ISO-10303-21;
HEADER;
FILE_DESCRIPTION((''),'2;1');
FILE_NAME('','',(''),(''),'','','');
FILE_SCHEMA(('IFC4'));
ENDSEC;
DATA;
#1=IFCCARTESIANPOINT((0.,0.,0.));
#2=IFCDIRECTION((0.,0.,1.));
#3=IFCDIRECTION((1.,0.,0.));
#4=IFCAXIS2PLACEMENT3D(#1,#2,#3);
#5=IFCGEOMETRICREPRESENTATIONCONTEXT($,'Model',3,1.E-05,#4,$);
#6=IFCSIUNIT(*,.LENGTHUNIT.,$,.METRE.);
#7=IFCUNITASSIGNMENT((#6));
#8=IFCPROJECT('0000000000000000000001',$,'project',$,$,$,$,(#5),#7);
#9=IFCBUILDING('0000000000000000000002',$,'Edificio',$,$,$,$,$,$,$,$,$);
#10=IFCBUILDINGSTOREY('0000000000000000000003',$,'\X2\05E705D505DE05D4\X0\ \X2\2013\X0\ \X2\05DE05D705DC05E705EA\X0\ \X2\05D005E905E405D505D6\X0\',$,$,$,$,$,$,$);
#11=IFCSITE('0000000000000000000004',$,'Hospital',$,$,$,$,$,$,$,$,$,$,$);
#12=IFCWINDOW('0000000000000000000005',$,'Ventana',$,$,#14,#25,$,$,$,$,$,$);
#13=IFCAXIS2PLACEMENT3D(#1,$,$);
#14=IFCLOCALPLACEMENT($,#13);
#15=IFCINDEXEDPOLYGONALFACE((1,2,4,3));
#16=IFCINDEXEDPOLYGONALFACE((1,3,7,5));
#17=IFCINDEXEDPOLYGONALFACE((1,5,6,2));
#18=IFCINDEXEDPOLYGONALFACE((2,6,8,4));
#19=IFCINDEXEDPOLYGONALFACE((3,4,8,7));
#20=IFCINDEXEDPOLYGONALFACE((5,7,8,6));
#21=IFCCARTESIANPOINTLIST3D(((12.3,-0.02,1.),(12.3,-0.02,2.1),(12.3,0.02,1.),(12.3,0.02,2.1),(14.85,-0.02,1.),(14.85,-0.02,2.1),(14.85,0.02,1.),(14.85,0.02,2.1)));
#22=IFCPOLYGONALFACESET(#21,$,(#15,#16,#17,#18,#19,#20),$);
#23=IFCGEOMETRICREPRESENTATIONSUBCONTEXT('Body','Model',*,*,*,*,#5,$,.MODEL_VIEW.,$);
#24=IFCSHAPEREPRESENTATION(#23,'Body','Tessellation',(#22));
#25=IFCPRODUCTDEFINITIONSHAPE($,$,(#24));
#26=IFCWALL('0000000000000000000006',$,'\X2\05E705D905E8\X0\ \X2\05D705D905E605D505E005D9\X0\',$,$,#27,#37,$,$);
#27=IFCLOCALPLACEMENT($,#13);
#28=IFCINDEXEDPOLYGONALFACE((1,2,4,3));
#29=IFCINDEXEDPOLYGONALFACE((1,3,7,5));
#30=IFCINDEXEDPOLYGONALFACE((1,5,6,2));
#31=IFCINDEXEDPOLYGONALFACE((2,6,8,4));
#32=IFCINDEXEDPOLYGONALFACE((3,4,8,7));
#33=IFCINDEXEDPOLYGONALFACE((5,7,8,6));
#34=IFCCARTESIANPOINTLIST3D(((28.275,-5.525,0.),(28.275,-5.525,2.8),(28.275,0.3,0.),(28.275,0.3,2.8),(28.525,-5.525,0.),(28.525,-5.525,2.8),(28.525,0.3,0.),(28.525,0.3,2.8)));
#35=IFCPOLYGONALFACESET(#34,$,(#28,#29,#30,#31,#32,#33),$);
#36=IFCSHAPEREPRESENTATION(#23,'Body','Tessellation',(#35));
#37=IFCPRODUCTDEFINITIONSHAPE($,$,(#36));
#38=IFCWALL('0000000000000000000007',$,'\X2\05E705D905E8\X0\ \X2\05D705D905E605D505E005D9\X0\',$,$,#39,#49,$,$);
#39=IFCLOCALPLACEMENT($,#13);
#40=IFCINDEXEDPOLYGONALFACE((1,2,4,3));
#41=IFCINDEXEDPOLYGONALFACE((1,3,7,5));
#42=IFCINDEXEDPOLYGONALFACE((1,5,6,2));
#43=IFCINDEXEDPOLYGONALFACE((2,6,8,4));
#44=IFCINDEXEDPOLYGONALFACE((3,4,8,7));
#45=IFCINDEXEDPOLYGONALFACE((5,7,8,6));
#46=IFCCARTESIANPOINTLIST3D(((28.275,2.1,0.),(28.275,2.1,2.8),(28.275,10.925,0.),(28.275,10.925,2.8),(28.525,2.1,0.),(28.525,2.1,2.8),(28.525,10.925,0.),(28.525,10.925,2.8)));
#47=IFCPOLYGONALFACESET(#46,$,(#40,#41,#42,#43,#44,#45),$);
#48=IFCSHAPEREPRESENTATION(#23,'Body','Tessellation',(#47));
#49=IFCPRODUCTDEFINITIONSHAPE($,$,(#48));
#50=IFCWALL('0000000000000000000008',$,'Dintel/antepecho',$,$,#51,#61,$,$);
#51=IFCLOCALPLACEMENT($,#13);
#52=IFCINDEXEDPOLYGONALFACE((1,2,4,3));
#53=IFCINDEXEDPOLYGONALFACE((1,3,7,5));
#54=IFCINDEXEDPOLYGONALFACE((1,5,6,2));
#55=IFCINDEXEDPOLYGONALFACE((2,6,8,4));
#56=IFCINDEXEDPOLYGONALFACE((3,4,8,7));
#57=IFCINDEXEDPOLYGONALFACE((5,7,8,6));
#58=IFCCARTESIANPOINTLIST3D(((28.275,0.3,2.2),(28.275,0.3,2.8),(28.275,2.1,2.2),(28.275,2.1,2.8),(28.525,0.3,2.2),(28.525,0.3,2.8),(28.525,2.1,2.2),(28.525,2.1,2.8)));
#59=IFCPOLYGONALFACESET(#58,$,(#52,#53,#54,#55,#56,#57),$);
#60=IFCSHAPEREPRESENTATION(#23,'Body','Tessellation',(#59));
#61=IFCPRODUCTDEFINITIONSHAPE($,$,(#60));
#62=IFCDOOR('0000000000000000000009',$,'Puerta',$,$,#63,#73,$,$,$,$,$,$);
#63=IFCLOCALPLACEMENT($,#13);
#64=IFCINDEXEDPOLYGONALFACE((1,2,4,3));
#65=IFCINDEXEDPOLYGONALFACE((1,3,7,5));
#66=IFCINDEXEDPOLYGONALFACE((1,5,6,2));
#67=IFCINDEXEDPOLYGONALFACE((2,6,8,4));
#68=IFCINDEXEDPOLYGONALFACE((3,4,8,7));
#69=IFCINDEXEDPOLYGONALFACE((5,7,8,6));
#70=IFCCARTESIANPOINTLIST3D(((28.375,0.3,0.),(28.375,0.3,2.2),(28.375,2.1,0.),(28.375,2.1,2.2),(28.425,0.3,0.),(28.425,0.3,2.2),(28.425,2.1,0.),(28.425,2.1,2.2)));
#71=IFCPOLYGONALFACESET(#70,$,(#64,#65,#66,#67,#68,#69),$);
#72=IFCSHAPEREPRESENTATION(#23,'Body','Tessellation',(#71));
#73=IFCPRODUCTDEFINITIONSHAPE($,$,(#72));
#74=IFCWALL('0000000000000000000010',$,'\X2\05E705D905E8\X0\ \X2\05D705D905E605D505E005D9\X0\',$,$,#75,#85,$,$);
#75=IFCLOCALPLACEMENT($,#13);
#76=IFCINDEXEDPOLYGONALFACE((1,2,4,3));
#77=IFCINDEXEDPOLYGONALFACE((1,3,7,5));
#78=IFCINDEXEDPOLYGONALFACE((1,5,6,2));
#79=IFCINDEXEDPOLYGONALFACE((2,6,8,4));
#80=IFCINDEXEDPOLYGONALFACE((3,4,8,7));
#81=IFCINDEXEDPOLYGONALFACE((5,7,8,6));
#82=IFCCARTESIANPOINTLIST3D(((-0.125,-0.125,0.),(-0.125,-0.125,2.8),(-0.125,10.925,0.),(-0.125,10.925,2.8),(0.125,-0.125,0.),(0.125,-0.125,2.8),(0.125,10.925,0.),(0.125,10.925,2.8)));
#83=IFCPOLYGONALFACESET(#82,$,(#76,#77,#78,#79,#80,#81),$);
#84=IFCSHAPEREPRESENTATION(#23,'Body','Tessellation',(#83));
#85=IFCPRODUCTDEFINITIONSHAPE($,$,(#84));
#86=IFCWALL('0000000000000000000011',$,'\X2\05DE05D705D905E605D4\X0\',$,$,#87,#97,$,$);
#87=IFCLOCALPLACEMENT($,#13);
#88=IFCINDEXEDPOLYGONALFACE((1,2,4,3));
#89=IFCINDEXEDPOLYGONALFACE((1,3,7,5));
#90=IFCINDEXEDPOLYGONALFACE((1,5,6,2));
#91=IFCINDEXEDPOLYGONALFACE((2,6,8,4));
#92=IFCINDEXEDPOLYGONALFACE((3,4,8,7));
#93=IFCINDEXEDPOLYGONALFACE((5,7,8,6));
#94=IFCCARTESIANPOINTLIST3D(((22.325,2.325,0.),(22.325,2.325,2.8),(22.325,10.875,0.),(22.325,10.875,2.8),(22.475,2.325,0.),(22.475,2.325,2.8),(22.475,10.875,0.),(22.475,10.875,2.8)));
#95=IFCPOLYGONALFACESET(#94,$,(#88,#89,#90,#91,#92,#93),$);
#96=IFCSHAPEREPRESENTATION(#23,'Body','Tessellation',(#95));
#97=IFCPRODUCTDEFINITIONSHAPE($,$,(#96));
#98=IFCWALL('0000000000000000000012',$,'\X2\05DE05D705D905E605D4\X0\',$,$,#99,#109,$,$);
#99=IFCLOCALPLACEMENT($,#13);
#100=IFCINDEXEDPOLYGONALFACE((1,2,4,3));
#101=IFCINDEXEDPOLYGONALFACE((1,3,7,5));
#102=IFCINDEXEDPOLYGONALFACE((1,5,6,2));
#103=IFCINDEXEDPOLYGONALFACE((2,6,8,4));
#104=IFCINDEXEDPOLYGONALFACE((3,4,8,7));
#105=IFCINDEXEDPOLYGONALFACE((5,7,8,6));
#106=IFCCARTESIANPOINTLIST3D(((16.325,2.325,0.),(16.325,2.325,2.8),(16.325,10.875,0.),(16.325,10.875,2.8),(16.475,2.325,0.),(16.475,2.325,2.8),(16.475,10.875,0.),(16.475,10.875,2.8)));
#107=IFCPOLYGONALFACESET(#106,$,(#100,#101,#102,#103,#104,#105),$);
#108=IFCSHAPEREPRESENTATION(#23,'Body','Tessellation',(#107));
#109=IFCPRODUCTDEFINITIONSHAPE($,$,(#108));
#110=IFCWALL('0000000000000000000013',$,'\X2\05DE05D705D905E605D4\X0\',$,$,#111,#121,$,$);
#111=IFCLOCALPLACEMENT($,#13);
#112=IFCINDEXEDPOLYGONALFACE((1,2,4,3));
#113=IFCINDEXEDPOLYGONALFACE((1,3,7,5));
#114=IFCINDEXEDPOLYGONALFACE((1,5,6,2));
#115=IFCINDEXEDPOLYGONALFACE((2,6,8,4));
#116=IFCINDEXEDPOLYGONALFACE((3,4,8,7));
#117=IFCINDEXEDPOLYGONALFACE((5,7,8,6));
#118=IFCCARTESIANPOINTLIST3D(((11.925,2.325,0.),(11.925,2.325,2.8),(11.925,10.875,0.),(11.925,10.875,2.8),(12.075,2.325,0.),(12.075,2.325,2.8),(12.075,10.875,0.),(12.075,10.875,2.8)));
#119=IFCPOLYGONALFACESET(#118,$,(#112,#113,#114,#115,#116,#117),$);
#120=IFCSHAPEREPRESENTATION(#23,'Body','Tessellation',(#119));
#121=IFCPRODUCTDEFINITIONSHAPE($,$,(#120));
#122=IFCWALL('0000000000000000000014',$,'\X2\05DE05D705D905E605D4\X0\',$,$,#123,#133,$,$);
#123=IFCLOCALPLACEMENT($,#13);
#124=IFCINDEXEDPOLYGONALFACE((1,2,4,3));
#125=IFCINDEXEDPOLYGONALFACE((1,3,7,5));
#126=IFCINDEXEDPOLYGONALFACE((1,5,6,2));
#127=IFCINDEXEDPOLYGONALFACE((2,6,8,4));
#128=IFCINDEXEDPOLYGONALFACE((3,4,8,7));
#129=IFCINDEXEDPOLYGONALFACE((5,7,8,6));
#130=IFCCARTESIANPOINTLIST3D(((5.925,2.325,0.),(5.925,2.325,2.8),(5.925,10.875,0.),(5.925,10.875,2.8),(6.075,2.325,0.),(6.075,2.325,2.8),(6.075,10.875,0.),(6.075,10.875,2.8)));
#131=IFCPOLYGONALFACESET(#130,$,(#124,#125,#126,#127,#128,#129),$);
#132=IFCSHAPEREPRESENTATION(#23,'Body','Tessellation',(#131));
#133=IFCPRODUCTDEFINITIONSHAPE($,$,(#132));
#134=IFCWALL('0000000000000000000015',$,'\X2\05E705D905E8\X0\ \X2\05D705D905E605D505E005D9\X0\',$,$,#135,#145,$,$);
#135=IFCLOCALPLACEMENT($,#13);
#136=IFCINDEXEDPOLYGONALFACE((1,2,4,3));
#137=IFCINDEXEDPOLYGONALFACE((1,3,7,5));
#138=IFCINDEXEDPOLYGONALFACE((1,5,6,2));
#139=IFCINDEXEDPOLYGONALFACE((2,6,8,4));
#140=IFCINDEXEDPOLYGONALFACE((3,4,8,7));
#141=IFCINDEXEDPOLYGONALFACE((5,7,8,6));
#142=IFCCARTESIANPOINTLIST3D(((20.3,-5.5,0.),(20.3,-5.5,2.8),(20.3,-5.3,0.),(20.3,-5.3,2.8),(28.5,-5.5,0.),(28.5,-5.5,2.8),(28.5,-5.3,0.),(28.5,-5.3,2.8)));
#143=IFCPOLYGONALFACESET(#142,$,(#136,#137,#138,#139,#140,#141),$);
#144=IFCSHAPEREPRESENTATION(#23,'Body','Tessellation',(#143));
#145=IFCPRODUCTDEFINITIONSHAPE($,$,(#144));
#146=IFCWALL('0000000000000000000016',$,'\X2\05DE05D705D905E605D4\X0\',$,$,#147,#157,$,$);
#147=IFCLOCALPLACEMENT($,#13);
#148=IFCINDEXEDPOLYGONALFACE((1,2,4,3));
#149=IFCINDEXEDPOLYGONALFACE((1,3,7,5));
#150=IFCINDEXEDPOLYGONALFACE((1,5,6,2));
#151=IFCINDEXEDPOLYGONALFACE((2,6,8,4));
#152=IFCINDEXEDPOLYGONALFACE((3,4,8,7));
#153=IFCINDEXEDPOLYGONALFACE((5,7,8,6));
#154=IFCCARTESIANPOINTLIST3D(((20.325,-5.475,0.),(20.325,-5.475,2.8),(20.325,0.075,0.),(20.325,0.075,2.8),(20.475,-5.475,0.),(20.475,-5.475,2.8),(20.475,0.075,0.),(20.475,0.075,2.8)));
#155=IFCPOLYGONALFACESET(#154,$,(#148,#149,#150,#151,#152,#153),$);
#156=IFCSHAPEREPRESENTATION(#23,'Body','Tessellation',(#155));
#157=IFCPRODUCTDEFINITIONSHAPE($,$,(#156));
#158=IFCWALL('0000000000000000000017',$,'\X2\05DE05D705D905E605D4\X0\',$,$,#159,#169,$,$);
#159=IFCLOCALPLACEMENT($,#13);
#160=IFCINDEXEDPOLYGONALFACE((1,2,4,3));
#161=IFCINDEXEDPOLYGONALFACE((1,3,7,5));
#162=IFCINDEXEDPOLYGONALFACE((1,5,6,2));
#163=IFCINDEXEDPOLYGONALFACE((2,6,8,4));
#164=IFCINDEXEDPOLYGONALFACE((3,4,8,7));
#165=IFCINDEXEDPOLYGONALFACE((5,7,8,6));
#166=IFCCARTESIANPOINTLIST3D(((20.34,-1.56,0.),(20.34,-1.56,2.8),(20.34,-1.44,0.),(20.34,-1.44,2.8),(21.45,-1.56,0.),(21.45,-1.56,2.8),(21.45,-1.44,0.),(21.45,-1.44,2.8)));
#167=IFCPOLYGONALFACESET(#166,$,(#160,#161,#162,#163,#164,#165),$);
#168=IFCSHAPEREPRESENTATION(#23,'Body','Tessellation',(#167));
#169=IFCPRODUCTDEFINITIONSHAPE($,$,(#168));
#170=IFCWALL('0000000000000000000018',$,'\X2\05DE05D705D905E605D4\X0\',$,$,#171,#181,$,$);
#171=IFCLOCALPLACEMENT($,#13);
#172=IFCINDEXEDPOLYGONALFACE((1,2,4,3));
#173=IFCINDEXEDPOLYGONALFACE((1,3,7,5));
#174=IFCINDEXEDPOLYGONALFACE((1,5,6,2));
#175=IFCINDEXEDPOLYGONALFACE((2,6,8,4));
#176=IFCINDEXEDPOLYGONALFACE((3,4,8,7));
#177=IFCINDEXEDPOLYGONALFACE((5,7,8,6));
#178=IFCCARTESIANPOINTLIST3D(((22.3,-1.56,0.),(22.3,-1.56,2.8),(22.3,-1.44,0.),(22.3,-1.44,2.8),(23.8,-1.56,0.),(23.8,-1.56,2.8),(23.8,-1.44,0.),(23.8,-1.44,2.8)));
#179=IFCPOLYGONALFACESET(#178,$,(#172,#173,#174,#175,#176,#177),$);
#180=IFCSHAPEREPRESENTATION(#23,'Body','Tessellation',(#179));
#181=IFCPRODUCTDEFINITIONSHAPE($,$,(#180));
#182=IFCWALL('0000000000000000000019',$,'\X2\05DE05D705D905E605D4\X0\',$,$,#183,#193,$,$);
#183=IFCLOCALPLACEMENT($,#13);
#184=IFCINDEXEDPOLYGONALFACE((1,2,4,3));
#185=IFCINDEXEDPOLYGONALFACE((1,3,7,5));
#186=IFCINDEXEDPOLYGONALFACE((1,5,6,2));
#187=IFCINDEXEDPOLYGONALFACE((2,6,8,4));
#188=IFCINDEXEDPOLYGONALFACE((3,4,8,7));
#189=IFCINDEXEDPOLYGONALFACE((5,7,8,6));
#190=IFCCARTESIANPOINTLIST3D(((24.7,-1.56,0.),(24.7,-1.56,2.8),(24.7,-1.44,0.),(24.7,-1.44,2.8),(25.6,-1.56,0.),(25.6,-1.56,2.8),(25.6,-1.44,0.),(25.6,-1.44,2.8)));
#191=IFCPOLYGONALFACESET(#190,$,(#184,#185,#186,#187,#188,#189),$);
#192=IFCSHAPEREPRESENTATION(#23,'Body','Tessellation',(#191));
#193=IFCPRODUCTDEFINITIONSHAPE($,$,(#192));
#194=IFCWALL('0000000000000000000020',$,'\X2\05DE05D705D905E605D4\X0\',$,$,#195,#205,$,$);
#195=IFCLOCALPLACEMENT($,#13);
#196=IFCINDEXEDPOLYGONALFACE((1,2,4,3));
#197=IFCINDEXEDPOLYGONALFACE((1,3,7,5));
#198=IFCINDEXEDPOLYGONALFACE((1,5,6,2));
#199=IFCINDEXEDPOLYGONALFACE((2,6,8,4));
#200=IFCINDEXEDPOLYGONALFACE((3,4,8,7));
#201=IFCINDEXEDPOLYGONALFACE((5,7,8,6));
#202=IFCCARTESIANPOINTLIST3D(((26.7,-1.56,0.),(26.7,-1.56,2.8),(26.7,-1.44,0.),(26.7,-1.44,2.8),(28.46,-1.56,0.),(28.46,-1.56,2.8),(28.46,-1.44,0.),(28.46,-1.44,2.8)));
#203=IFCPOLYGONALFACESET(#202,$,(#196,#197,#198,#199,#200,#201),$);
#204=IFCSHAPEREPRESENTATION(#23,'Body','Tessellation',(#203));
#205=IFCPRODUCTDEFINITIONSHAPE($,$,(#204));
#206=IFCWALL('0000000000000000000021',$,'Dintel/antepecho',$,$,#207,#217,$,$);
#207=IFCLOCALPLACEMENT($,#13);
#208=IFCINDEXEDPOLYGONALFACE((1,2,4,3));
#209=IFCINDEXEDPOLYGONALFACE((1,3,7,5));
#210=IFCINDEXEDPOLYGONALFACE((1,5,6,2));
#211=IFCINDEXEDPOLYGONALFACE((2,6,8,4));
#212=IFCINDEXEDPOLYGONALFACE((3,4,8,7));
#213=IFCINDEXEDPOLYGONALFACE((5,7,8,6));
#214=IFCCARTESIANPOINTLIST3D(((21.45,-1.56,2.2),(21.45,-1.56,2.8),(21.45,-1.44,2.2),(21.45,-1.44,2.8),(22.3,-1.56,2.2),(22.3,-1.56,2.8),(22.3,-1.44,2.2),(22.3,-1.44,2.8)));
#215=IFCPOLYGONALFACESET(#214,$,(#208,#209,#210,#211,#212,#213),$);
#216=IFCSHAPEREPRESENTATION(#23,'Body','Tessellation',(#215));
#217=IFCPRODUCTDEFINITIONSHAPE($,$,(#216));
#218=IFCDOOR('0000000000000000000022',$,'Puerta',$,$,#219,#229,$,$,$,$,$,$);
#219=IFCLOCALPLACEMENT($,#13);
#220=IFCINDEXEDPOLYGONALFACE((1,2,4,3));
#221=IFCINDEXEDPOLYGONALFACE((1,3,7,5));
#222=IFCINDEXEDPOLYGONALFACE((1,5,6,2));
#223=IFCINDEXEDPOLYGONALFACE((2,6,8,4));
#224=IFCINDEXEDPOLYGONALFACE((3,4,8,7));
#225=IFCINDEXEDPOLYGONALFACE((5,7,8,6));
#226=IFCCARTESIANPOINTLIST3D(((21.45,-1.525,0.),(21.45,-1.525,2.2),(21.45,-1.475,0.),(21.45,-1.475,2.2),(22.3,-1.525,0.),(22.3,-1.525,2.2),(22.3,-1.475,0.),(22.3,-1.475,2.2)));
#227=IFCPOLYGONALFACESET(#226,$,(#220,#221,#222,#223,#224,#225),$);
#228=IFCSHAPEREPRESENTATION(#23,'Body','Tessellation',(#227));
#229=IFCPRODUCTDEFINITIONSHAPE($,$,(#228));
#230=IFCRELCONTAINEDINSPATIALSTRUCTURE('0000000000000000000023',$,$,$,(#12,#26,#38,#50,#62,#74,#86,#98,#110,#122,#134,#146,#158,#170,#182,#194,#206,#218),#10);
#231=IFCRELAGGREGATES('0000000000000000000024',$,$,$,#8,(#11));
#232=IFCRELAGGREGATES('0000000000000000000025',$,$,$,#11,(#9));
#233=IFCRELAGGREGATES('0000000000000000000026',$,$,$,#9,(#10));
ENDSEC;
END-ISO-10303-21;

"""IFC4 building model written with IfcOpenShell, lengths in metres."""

from ifc_helpers import new_model, si_unit, frame, origin_with_axes, context, subcontext, project, spatial, line, indexed_curve, outline, extrude, element, save


model = new_model("IFC4")

# Units and contexts
model_context = context("Model", 3, precision=1e-05, world=origin_with_axes())
body_context = subcontext(model_context, "Body", "Model", "MODEL_VIEW")
ifc_project = project(units=[si_unit("LENGTHUNIT", "METRE")], contexts=[model_context])

# Site, building, storey
site = spatial("IfcSite", under=ifc_project, Name="Hospital")
building = spatial("IfcBuilding", under=site, Name="Edificio")
storey = spatial("IfcBuildingStorey", under=building, Name="קומה – מחלקת אשפוז")

# Window
element("IfcWindow", 1, inside=storey, Name="Ventana", context=body_context, shape_type="SweptSolid", body=[
    extrude(outline(indexed_curve([(0.0, 0.0), (2.55, 0.0), (2.55, 0.04), (0.0, 0.04)], segments=[line(1, 2, 3, 4, 1)])), frame((12.3, -0.02, 1.0), z_axis=(0.0, 0.0, 1.0), x_axis=(1.0, 0.0, 0.0)), (0.0, 0.0, 1.0), 1.1),
])

# Walls
element("IfcWall", 2, inside=storey, Name="קיר חיצוני", context=body_context, shape_type="SweptSolid", body=[
    extrude(outline(indexed_curve([(0.0, 0.0), (0.25, 0.0), (0.25, 5.825), (0.0, 5.825)], segments=[line(1, 2, 3, 4, 1)])), frame((28.275, -5.525, 0.0), z_axis=(0.0, 0.0, 1.0), x_axis=(1.0, 0.0, 0.0)), (0.0, 0.0, 1.0), 2.8),
])
element("IfcWall", 3, inside=storey, Name="קיר חיצוני", context=body_context, shape_type="SweptSolid", body=[
    extrude(outline(indexed_curve([(0.0, 0.0), (0.25, 0.0), (0.25, 8.825), (0.0, 8.825)], segments=[line(1, 2, 3, 4, 1)])), frame((28.275, 2.1, 0.0), z_axis=(0.0, 0.0, 1.0), x_axis=(1.0, 0.0, 0.0)), (0.0, 0.0, 1.0), 2.8),
])
element("IfcWall", 4, inside=storey, Name="Dintel/antepecho", context=body_context, shape_type="SweptSolid", body=[
    extrude(outline(indexed_curve([(0.0, 0.0), (0.25, 0.0), (0.25, 1.8), (0.0, 1.8)], segments=[line(1, 2, 3, 4, 1)])), frame((28.275, 0.3, 2.2), z_axis=(0.0, 0.0, 1.0), x_axis=(1.0, 0.0, 0.0)), (0.0, 0.0, 1.0), 0.6),
])

# Door
element("IfcDoor", 5, inside=storey, Name="Puerta", context=body_context, shape_type="SweptSolid", body=[
    extrude(outline(indexed_curve([(0.0, 0.0), (0.05, 0.0), (0.05, 1.8), (0.0, 1.8)], segments=[line(1, 2, 3, 4, 1)])), frame((28.375, 0.3, 0.0), z_axis=(0.0, 0.0, 1.0), x_axis=(1.0, 0.0, 0.0)), (0.0, 0.0, 1.0), 2.2),
])

# Walls
element("IfcWall", 6, inside=storey, Name="קיר חיצוני", context=body_context, shape_type="SweptSolid", body=[
    extrude(outline(indexed_curve([(0.0, 0.0), (0.25, 0.0), (0.25, 11.05), (0.0, 11.05)], segments=[line(1, 2, 3, 4, 1)])), frame((-0.125, -0.125, 0.0), z_axis=(0.0, 0.0, 1.0), x_axis=(1.0, 0.0, 0.0)), (0.0, 0.0, 1.0), 2.8),
])
element("IfcWall", 7, inside=storey, Name="מחיצה", context=body_context, shape_type="SweptSolid", body=[
    extrude(outline(indexed_curve([(0.0, 0.0), (0.15, 0.0), (0.15, 8.55), (0.0, 8.55)], segments=[line(1, 2, 3, 4, 1)])), frame((22.325, 2.325, 0.0), z_axis=(0.0, 0.0, 1.0), x_axis=(1.0, 0.0, 0.0)), (0.0, 0.0, 1.0), 2.8),
])
element("IfcWall", 8, inside=storey, Name="מחיצה", context=body_context, shape_type="SweptSolid", body=[
    extrude(outline(indexed_curve([(0.0, 0.0), (0.15, 0.0), (0.15, 8.55), (0.0, 8.55)], segments=[line(1, 2, 3, 4, 1)])), frame((16.325, 2.325, 0.0), z_axis=(0.0, 0.0, 1.0), x_axis=(1.0, 0.0, 0.0)), (0.0, 0.0, 1.0), 2.8),
])
element("IfcWall", 9, inside=storey, Name="מחיצה", context=body_context, shape_type="SweptSolid", body=[
    extrude(outline(indexed_curve([(0.0, 0.0), (0.15, 0.0), (0.15, 8.55), (0.0, 8.55)], segments=[line(1, 2, 3, 4, 1)])), frame((11.925, 2.325, 0.0), z_axis=(0.0, 0.0, 1.0), x_axis=(1.0, 0.0, 0.0)), (0.0, 0.0, 1.0), 2.8),
])
element("IfcWall", 10, inside=storey, Name="מחיצה", context=body_context, shape_type="SweptSolid", body=[
    extrude(outline(indexed_curve([(0.0, 0.0), (0.15, 0.0), (0.15, 8.55), (0.0, 8.55)], segments=[line(1, 2, 3, 4, 1)])), frame((5.925, 2.325, 0.0), z_axis=(0.0, 0.0, 1.0), x_axis=(1.0, 0.0, 0.0)), (0.0, 0.0, 1.0), 2.8),
])
element("IfcWall", 11, inside=storey, Name="קיר חיצוני", context=body_context, shape_type="SweptSolid", body=[
    extrude(outline(indexed_curve([(0.0, 0.0), (8.2, 0.0), (8.2, 0.2), (0.0, 0.2)], segments=[line(1, 2, 3, 4, 1)])), frame((20.3, -5.5, 0.0), z_axis=(0.0, 0.0, 1.0), x_axis=(1.0, 0.0, 0.0)), (0.0, 0.0, 1.0), 2.8),
])
element("IfcWall", 12, inside=storey, Name="מחיצה", context=body_context, shape_type="SweptSolid", body=[
    extrude(outline(indexed_curve([(0.0, 0.0), (0.15, 0.0), (0.15, 5.55), (0.0, 5.55)], segments=[line(1, 2, 3, 4, 1)])), frame((20.325, -5.475, 0.0), z_axis=(0.0, 0.0, 1.0), x_axis=(1.0, 0.0, 0.0)), (0.0, 0.0, 1.0), 2.8),
])
element("IfcWall", 13, inside=storey, Name="מחיצה", context=body_context, shape_type="SweptSolid", body=[
    extrude(outline(indexed_curve([(0.0, 0.0), (1.11, 0.0), (1.11, 0.12), (0.0, 0.12)], segments=[line(1, 2, 3, 4, 1)])), frame((20.34, -1.56, 0.0), z_axis=(0.0, 0.0, 1.0), x_axis=(1.0, 0.0, 0.0)), (0.0, 0.0, 1.0), 2.8),
])
element("IfcWall", 14, inside=storey, Name="מחיצה", context=body_context, shape_type="SweptSolid", body=[
    extrude(outline(indexed_curve([(0.0, 0.0), (1.5, 0.0), (1.5, 0.12), (0.0, 0.12)], segments=[line(1, 2, 3, 4, 1)])), frame((22.3, -1.56, 0.0), z_axis=(0.0, 0.0, 1.0), x_axis=(1.0, 0.0, 0.0)), (0.0, 0.0, 1.0), 2.8),
])
element("IfcWall", 15, inside=storey, Name="מחיצה", context=body_context, shape_type="SweptSolid", body=[
    extrude(outline(indexed_curve([(0.0, 0.0), (0.9, 0.0), (0.9, 0.12), (0.0, 0.12)], segments=[line(1, 2, 3, 4, 1)])), frame((24.7, -1.56, 0.0), z_axis=(0.0, 0.0, 1.0), x_axis=(1.0, 0.0, 0.0)), (0.0, 0.0, 1.0), 2.8),
])
element("IfcWall", 16, inside=storey, Name="מחיצה", context=body_context, shape_type="SweptSolid", body=[
    extrude(outline(indexed_curve([(0.0, 0.0), (1.76, 0.0), (1.76, 0.12), (0.0, 0.12)], segments=[line(1, 2, 3, 4, 1)])), frame((26.7, -1.56, 0.0), z_axis=(0.0, 0.0, 1.0), x_axis=(1.0, 0.0, 0.0)), (0.0, 0.0, 1.0), 2.8),
])
element("IfcWall", 17, inside=storey, Name="Dintel/antepecho", context=body_context, shape_type="SweptSolid", body=[
    extrude(outline(indexed_curve([(0.0, 0.0), (0.85, 0.0), (0.85, 0.12), (0.0, 0.12)], segments=[line(1, 2, 3, 4, 1)])), frame((21.45, -1.56, 2.2), z_axis=(0.0, 0.0, 1.0), x_axis=(1.0, 0.0, 0.0)), (0.0, 0.0, 1.0), 0.6),
])

# Door
element("IfcDoor", 18, inside=storey, Name="Puerta", context=body_context, shape_type="SweptSolid", body=[
    extrude(outline(indexed_curve([(0.0, 0.0), (0.85, 0.0), (0.85, 0.05), (0.0, 0.05)], segments=[line(1, 2, 3, 4, 1)])), frame((21.45, -1.525, 0.0), z_axis=(0.0, 0.0, 1.0), x_axis=(1.0, 0.0, 0.0)), (0.0, 0.0, 1.0), 2.2),
])

save(model, "model.ifc")
